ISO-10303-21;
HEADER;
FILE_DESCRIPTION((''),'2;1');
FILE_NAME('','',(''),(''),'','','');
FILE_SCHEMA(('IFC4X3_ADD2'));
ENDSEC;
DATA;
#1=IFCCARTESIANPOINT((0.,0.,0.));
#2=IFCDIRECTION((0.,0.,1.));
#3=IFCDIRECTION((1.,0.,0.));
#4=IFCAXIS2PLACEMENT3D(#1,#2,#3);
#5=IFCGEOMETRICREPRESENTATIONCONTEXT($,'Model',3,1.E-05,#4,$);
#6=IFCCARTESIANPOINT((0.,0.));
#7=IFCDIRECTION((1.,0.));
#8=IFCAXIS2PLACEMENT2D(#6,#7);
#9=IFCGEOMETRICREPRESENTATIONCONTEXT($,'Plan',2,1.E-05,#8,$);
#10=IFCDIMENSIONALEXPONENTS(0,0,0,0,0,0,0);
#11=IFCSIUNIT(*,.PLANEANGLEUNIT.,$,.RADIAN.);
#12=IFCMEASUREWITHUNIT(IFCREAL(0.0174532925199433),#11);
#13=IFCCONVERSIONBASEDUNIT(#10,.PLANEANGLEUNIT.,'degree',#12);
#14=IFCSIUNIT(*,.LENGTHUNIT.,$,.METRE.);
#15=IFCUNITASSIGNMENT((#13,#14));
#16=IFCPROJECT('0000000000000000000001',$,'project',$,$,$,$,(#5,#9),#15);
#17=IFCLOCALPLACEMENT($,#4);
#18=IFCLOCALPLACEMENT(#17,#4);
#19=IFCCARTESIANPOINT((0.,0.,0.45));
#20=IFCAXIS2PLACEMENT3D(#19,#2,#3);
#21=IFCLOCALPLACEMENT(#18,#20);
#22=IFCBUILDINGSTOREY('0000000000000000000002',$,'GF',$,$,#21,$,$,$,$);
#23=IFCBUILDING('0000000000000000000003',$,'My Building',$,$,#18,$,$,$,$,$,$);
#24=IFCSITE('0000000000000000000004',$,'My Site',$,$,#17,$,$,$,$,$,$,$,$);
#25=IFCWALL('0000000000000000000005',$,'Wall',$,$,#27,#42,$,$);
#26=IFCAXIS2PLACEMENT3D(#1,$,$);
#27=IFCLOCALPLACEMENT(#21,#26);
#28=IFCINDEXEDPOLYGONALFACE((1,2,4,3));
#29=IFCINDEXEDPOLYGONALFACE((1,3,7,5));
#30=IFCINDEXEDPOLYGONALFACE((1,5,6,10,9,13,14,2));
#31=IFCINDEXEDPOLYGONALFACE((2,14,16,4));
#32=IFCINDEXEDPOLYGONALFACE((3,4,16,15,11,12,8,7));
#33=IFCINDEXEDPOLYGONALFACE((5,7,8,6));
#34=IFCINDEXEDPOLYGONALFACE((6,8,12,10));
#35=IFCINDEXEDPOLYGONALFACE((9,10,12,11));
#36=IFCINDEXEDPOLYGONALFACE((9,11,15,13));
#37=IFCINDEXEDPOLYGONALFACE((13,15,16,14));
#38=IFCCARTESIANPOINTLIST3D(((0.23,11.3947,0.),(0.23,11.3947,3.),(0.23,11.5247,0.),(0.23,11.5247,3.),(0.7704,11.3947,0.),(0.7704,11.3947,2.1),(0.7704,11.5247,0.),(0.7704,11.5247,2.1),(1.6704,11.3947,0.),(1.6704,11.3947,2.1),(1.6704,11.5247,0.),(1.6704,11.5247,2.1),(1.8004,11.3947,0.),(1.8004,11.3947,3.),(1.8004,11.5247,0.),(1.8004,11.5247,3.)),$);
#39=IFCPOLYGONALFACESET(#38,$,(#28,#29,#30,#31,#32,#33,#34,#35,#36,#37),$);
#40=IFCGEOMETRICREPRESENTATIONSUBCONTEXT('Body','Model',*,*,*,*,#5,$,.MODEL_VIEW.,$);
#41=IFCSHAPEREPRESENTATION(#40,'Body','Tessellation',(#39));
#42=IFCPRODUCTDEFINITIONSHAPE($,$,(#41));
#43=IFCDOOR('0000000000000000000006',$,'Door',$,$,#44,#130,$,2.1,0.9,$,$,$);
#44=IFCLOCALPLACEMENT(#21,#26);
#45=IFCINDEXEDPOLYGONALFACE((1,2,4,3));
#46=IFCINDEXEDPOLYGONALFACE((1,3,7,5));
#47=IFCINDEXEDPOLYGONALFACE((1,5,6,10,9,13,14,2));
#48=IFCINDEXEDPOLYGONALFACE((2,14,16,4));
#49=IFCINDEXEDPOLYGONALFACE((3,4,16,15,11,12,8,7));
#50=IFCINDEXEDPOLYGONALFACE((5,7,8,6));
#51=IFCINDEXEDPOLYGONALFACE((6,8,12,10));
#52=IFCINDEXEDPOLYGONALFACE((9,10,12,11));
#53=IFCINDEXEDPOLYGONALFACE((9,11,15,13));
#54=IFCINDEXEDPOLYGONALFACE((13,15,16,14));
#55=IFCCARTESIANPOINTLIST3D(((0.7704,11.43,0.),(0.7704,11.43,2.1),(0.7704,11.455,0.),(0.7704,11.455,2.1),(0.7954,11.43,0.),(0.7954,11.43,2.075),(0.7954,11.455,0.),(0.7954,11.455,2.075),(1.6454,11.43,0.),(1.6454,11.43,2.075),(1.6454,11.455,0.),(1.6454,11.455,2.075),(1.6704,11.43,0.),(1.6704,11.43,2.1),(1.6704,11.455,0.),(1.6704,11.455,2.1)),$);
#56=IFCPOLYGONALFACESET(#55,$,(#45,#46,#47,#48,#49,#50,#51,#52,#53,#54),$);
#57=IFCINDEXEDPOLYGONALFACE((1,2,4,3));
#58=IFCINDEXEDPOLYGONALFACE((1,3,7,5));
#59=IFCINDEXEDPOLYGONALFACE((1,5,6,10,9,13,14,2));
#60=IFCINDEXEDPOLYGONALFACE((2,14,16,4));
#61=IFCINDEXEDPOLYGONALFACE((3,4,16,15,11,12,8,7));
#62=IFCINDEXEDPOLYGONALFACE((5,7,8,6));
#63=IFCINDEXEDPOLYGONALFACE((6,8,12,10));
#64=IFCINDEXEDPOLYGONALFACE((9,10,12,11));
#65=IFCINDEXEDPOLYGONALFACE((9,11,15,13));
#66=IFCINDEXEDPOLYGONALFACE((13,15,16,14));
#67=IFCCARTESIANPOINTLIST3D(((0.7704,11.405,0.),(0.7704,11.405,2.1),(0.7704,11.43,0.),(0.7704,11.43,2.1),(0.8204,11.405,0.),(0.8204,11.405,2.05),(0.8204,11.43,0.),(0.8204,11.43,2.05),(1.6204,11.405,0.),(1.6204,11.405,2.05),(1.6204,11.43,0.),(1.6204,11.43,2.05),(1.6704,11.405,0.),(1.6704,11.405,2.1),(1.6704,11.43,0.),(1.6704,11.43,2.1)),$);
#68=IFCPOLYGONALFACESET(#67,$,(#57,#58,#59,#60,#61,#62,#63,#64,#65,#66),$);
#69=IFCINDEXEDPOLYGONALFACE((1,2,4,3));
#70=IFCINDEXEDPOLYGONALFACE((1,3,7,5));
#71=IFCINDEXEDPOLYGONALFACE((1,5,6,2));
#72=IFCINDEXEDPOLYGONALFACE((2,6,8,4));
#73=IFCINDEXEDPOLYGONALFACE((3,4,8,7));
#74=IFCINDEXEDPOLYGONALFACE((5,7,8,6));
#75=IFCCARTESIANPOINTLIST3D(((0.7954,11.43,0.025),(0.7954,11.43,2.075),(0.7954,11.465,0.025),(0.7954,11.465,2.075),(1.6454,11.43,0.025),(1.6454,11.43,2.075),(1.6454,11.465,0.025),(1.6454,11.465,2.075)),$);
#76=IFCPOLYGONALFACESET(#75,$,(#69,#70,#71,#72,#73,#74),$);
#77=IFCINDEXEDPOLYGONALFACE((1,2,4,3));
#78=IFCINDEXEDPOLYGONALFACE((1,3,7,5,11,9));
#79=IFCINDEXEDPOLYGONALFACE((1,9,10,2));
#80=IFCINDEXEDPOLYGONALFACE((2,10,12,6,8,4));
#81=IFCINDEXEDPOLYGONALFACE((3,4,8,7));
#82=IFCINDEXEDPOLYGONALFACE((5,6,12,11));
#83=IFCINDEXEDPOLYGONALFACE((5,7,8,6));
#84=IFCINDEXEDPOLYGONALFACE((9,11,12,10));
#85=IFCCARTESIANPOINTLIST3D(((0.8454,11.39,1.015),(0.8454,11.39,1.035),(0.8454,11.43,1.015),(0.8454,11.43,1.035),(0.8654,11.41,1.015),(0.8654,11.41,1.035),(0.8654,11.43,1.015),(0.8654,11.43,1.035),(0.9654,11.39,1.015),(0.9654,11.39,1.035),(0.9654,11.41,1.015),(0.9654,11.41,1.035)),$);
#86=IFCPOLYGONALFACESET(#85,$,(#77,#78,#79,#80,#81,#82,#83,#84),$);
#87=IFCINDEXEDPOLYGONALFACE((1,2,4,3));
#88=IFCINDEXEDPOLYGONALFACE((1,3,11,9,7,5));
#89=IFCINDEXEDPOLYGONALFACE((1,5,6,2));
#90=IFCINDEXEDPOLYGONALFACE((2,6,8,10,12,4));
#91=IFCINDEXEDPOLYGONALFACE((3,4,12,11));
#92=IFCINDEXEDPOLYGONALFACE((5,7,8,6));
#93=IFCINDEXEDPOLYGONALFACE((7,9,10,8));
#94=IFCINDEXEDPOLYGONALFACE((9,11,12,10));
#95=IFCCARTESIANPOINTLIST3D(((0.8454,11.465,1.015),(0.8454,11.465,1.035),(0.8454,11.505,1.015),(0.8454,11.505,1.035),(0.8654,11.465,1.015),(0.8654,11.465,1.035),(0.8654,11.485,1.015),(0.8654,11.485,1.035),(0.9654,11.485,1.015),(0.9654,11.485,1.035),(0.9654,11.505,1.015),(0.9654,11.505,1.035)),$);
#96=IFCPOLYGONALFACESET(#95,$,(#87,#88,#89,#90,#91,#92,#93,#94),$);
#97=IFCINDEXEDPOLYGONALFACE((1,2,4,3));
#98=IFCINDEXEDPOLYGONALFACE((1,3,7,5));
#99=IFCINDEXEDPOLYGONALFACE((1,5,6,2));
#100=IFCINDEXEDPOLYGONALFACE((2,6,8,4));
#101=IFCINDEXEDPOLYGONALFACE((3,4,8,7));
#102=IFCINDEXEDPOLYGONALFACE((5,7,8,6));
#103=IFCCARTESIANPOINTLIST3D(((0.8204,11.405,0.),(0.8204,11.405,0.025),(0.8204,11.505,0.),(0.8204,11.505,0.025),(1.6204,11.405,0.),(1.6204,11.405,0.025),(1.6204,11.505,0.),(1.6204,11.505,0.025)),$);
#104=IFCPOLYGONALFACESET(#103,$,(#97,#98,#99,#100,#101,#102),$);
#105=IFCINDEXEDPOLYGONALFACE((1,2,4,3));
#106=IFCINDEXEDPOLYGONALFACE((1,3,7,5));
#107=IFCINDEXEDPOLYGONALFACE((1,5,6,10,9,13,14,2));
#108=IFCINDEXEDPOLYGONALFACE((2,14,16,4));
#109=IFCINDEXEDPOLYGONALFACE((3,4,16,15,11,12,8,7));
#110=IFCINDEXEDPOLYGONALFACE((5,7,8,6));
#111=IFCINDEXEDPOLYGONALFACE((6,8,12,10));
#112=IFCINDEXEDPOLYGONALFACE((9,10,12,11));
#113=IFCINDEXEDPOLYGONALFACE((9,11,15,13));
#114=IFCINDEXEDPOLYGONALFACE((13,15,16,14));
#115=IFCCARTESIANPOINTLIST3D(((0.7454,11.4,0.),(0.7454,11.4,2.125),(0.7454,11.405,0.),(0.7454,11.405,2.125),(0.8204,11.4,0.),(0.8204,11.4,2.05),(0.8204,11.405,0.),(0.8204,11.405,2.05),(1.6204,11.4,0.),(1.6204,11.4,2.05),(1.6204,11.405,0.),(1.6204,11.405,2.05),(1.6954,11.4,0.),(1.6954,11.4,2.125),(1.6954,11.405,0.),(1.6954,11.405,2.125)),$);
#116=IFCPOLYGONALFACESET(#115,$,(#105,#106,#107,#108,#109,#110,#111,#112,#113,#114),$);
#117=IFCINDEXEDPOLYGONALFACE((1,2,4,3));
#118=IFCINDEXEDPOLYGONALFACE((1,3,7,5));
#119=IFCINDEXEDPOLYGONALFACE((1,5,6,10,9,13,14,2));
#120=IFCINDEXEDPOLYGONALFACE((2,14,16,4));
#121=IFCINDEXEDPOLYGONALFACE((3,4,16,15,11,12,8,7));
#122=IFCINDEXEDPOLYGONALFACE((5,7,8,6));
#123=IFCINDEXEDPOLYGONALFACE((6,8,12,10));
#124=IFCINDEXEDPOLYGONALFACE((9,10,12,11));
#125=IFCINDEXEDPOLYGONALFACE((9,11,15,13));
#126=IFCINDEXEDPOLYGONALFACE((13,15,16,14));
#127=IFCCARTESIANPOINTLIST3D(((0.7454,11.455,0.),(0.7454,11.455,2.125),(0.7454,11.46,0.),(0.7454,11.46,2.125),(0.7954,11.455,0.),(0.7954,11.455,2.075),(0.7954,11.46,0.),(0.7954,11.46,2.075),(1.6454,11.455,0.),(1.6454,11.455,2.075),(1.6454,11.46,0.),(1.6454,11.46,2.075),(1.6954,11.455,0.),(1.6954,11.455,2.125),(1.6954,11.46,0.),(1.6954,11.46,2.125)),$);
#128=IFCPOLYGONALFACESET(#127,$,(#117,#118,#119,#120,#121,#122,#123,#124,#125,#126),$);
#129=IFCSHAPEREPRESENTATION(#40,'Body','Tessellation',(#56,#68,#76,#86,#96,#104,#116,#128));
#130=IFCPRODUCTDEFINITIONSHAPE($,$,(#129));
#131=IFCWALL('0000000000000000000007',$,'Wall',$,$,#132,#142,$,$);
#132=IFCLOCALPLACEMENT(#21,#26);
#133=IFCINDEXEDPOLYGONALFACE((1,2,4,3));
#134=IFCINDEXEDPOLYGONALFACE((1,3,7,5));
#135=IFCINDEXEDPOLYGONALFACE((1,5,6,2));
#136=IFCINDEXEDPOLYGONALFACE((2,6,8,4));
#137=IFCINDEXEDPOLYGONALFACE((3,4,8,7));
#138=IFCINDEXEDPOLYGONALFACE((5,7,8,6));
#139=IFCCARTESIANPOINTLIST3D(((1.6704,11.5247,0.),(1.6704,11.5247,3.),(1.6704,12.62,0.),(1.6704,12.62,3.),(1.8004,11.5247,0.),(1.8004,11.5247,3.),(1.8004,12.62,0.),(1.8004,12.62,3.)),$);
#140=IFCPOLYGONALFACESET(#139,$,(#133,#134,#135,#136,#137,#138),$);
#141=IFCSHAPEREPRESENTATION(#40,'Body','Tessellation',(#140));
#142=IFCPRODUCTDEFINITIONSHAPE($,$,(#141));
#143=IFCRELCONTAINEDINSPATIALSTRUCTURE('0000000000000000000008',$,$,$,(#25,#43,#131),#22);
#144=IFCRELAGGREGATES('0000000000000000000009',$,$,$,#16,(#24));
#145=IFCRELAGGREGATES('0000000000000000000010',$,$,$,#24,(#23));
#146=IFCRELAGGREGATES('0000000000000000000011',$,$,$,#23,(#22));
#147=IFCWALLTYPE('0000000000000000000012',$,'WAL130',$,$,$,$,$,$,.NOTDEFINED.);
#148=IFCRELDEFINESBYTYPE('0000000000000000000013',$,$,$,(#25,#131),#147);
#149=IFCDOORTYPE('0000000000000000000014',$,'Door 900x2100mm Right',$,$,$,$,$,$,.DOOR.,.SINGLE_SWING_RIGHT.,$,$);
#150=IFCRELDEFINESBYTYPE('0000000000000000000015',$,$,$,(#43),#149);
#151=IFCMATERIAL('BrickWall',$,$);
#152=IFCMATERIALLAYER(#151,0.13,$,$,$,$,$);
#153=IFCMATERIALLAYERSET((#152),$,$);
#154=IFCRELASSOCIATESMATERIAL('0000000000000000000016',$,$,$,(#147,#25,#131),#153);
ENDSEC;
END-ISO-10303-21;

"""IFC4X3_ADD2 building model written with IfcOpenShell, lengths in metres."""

from ifc_helpers import new_model, entity, si_unit, converted_unit, frame, origin_with_axes, origin_2d_with_axis, place, context, subcontext, project, spatial, line, indexed_curve, outline, extrude, shape, source, transform, mapped, material, layer, layer_set, layer_usage, type_object, type_shapes, element, fill, save


model = new_model("IFC4X3_ADD2")

# Units and contexts
model_context = context("Model", 3, precision=1e-05, world=origin_with_axes())
plan_context = context("Plan", 2, precision=1e-05, world=origin_2d_with_axis())
body_context_1 = subcontext(model_context, "Body", "Model", "MODEL_VIEW")
body_context_2 = subcontext(plan_context, "Body", "Plan", "PLAN_VIEW")
ifc_project = project(units=[converted_unit("PLANEANGLEUNIT", "degree", entity("IfcReal", 0.0174532925199433), si_unit("PLANEANGLEUNIT", "RADIAN"), dimensions=[0, 0, 0, 0, 0, 0, 0]), si_unit("LENGTHUNIT", "METRE")], contexts=[model_context, plan_context])

# Site, building, storey
site_placement = place(None, origin_with_axes())
site = spatial("IfcSite", under=ifc_project, at=site_placement, Name="My Site")
building_placement = place(site_placement, origin_with_axes())
building = spatial("IfcBuilding", under=site, at=building_placement, Name="My Building")
storey_placement = place(building_placement, frame((0.0, 0.0, 0.45), z_axis=(0.0, 0.0, 1.0), x_axis=(1.0, 0.0, 0.0)))
storey = spatial("IfcBuildingStorey", under=building, at=storey_placement, Name="GF")

# Shared definitions
ifc_material_1 = material(Name="BrickWall")

# Shared definitions
ifc_layer_1 = layer(ifc_material_1, 0.13)
ifc_layer_set_1 = layer_set([ifc_layer_1])
wall_type_1 = type_object("IfcWallType", Name="WAL130", PredefinedType="NOTDEFINED", material=ifc_layer_set_1)

# Wall, opening, door
ifc_layer_usage_1 = layer_usage(ifc_layer_set_1, "AXIS2", "POSITIVE", 0.0)
wall_1_placement = place(storey_placement, frame((0.23, 11.3947, 0.0), z_axis=(0.0, 0.0, 1.0), x_axis=(1.0, 0.0, 0.0)))
wall_1 = element("IfcWall", 1, at=wall_1_placement, inside=storey, type_object=wall_type_1, material=ifc_layer_usage_1, Name="Wall", context=body_context_1, shape_type="SweptSolid", body=[
    extrude(outline(indexed_curve([(0.0, 0.0), (0.0, 0.13), (1.5704, 0.13), (1.5704, 0.0), (0.0, 0.0)], self_intersect=False)), origin_with_axes(), (0.0, 0.0, 1.0), 3.0),
])
shared_shape_1 = source(origin_with_axes(), body_context_1, "Body", "SweptSolid", [
    extrude(outline(indexed_curve([(0.0, 0.0), (0.9, 0.0), (0.9, 2.1), (0.0, 2.1)], segments=[line(1, 2, 3, 4, 1)])), frame((0.0, -0.6, 0.0), z_axis=(0.0, -1.0, 0.0), x_axis=(1.0, 0.0, 0.0)), (0.0, 0.0, -1.0), 1.2),
])
opening_1_placement = place(wall_1_placement, frame((0.5404, 0.0103, 0.0), z_axis=(0.0, 0.0, 1.0), x_axis=(1.0, 0.0, 0.0)))
opening_1 = element("IfcOpeningElement", 2, at=opening_1_placement, cuts=wall_1, PredefinedType="OPENING", context=body_context_1, shape_type="MappedRepresentation", body=[
    mapped(shared_shape_1, transform((0.0, 0.0, 0.0), x_axis=(1.0, 0.0, 0.0), y_axis=(0.0, 1.0, 0.0), z_axis=(0.0, 0.0, 1.0), scale=1.0)),
])
door_type_1 = type_object("IfcDoorType", Name="Door 900x2100mm Right", OperationType="SINGLE_SWING_RIGHT", PredefinedType="DOOR")
shared_shape_2 = source(origin_with_axes(), body_context_1, "Body", "SweptSolid", [
    extrude(outline(indexed_curve([(0.0, 0.0), (0.0, 2.1), (0.9, 2.1), (0.9, 0.0), (0.875, 0.0), (0.875, 2.075), (0.025, 2.075), (0.025, 0.0)], segments=[line(1, 2, 3, 4, 5, 6, 7, 8, 1)])), frame((0.0, 0.025, 0.0), z_axis=(0.0, -1.0, 0.0), x_axis=(1.0, 0.0, 0.0)), (0.0, 0.0, -1.0), 0.025),
    extrude(outline(indexed_curve([(0.0, 0.0), (0.0, 2.1), (0.9, 2.1), (0.9, 0.0), (0.85, 0.0), (0.85, 2.05), (0.05, 2.05), (0.05, 0.0)], segments=[line(1, 2, 3, 4, 5, 6, 7, 8, 1)])), frame((0.0, 0.0, 0.0), z_axis=(0.0, -1.0, 0.0), x_axis=(1.0, 0.0, 0.0)), (0.0, 0.0, -1.0), 0.025),
    extrude(outline(indexed_curve([(0.0, 0.0), (0.85, 0.0), (0.85, 0.035), (0.0, 0.035)], segments=[line(1, 2, 3, 4, 1)])), frame((0.025, 0.025, 0.025), z_axis=(0.0, 0.0, 1.0), x_axis=(1.0, 0.0, 0.0)), (0.0, 0.0, 1.0), 2.05),
    extrude(outline(indexed_curve([(0.0, 0.0), (0.0, -0.04), (0.12, -0.04), (0.12, -0.02), (0.02, -0.02), (0.02, 0.0)], segments=[line(1, 2, 3, 4, 5, 6, 1)])), frame((0.075, 0.025, 1.015), z_axis=(0.0, 0.0, 1.0), x_axis=(1.0, 0.0, 0.0)), (0.0, 0.0, 1.0), 0.02),
    extrude(outline(indexed_curve([(0.0, 0.0), (0.0, 0.04), (0.12, 0.04), (0.12, 0.02), (0.02, 0.02), (0.02, 0.0)], segments=[line(1, 2, 3, 4, 5, 6, 1)])), frame((0.075, 0.06, 1.015), z_axis=(0.0, 0.0, 1.0), x_axis=(1.0, 0.0, 0.0)), (0.0, 0.0, 1.0), 0.02),
    extrude(outline(indexed_curve([(0.0, 0.0), (0.8, 0.0), (0.8, 0.1), (0.0, 0.1)], segments=[line(1, 2, 3, 4, 1)])), frame((0.05, 0.0, 0.0), z_axis=(0.0, 0.0, 1.0), x_axis=(1.0, 0.0, 0.0)), (0.0, 0.0, 1.0), 0.025),
    extrude(outline(indexed_curve([(0.0, 0.0), (0.0, 2.125), (0.95, 2.125), (0.95, 0.0), (0.875, 0.0), (0.875, 2.05), (0.075, 2.05), (0.075, 0.0)], segments=[line(1, 2, 3, 4, 5, 6, 7, 8, 1)])), frame((-0.025, -0.005, 0.0), z_axis=(0.0, -1.0, 0.0), x_axis=(1.0, 0.0, 0.0)), (0.0, 0.0, -1.0), 0.005),
    extrude(outline(indexed_curve([(0.0, 0.0), (0.0, 2.125), (0.95, 2.125), (0.95, 0.0), (0.9, 0.0), (0.9, 2.075), (0.05, 2.075), (0.05, 0.0)], segments=[line(1, 2, 3, 4, 5, 6, 7, 8, 1)])), frame((-0.025, 0.05, 0.0), z_axis=(0.0, -1.0, 0.0), x_axis=(1.0, 0.0, 0.0)), (0.0, 0.0, -1.0), 0.005),
])
shared_shape_3 = source(origin_with_axes(), body_context_2, "Body", "Curve2D", [
    entity("IfcIndexedPolyCurve", entity("IfcCartesianPointList2D", [[0.0, 0.0], [0.0, 0.05], [0.025, 0.05], [0.025, 0.025], [0.05, 0.025], [0.05, 0.0]]), [entity("IfcLineIndex", [1, 2, 3, 4, 5, 6, 1])]),
    entity("IfcIndexedPolyCurve", entity("IfcCartesianPointList2D", [[0.9, 0.0], [0.9, 0.05], [0.875, 0.05], [0.875, 0.025], [0.85, 0.025], [0.85, 0.0]]), [entity("IfcLineIndex", [1, 2, 3, 4, 5, 6, 1])]),
    entity("IfcTrimmedCurve", entity("IfcEllipse", entity("IfcAxis2Placement2D", entity("IfcCartesianPoint", [0.84, 0.05]), entity("IfcDirection", [1.0, 0.0])), 0.815, 0.85), [entity("IfcCartesianPoint", [0.84, 0.9])], [entity("IfcCartesianPoint", [0.025, 0.05])], True, "CARTESIAN"),
    entity("IfcIndexedPolyCurve", entity("IfcCartesianPointList2D", [[0.875, 0.05], [0.84, 0.05], [0.84, 0.9], [0.875, 0.9]]), [entity("IfcLineIndex", [1, 2, 3, 4, 1])]),
])
type_shapes(door_type_1, [shared_shape_2, shared_shape_3])
door_1_placement = place(opening_1_placement, origin_with_axes())
door_1 = element("IfcDoor", 3, at=door_1_placement, inside=storey, type_object=door_type_1, Name="Door", OverallHeight=2.1, OverallWidth=0.9, shapes=[
    shape(body_context_1, "Body", "MappedRepresentation", [mapped(shared_shape_2, transform((0.0, 0.0, 0.0), x_axis=(1.0, 0.0, 0.0), y_axis=(0.0, 1.0, 0.0), z_axis=(0.0, 0.0, 1.0), scale=1.0))]),
    shape(body_context_2, "Body", "MappedRepresentation", [mapped(shared_shape_3, transform((0.0, 0.0, 0.0), x_axis=(1.0, 0.0, 0.0), y_axis=(0.0, 1.0, 0.0), z_axis=(0.0, 0.0, 1.0), scale=1.0))]),
])
fill(opening_1, door_1)

# Wall
ifc_layer_usage_2 = layer_usage(ifc_layer_set_1, "AXIS2", "POSITIVE", 0.0)
wall_2_placement = place(storey_placement, frame((1.8004, 11.5247, 0.0), z_axis=(0.0, 0.0, 1.0), x_axis=(0.0, 1.0, 0.0)))
element("IfcWall", 4, at=wall_2_placement, inside=storey, type_object=wall_type_1, material=ifc_layer_usage_2, Name="Wall", context=body_context_1, shape_type="SweptSolid", body=[
    extrude(outline(indexed_curve([(0.0, 0.0), (0.0, 0.13), (1.0953, 0.13), (1.0953, 0.0), (0.0, 0.0)], self_intersect=False)), origin_with_axes(), (0.0, 0.0, 1.0), 3.0),
])

save(model, "model.ifc")
